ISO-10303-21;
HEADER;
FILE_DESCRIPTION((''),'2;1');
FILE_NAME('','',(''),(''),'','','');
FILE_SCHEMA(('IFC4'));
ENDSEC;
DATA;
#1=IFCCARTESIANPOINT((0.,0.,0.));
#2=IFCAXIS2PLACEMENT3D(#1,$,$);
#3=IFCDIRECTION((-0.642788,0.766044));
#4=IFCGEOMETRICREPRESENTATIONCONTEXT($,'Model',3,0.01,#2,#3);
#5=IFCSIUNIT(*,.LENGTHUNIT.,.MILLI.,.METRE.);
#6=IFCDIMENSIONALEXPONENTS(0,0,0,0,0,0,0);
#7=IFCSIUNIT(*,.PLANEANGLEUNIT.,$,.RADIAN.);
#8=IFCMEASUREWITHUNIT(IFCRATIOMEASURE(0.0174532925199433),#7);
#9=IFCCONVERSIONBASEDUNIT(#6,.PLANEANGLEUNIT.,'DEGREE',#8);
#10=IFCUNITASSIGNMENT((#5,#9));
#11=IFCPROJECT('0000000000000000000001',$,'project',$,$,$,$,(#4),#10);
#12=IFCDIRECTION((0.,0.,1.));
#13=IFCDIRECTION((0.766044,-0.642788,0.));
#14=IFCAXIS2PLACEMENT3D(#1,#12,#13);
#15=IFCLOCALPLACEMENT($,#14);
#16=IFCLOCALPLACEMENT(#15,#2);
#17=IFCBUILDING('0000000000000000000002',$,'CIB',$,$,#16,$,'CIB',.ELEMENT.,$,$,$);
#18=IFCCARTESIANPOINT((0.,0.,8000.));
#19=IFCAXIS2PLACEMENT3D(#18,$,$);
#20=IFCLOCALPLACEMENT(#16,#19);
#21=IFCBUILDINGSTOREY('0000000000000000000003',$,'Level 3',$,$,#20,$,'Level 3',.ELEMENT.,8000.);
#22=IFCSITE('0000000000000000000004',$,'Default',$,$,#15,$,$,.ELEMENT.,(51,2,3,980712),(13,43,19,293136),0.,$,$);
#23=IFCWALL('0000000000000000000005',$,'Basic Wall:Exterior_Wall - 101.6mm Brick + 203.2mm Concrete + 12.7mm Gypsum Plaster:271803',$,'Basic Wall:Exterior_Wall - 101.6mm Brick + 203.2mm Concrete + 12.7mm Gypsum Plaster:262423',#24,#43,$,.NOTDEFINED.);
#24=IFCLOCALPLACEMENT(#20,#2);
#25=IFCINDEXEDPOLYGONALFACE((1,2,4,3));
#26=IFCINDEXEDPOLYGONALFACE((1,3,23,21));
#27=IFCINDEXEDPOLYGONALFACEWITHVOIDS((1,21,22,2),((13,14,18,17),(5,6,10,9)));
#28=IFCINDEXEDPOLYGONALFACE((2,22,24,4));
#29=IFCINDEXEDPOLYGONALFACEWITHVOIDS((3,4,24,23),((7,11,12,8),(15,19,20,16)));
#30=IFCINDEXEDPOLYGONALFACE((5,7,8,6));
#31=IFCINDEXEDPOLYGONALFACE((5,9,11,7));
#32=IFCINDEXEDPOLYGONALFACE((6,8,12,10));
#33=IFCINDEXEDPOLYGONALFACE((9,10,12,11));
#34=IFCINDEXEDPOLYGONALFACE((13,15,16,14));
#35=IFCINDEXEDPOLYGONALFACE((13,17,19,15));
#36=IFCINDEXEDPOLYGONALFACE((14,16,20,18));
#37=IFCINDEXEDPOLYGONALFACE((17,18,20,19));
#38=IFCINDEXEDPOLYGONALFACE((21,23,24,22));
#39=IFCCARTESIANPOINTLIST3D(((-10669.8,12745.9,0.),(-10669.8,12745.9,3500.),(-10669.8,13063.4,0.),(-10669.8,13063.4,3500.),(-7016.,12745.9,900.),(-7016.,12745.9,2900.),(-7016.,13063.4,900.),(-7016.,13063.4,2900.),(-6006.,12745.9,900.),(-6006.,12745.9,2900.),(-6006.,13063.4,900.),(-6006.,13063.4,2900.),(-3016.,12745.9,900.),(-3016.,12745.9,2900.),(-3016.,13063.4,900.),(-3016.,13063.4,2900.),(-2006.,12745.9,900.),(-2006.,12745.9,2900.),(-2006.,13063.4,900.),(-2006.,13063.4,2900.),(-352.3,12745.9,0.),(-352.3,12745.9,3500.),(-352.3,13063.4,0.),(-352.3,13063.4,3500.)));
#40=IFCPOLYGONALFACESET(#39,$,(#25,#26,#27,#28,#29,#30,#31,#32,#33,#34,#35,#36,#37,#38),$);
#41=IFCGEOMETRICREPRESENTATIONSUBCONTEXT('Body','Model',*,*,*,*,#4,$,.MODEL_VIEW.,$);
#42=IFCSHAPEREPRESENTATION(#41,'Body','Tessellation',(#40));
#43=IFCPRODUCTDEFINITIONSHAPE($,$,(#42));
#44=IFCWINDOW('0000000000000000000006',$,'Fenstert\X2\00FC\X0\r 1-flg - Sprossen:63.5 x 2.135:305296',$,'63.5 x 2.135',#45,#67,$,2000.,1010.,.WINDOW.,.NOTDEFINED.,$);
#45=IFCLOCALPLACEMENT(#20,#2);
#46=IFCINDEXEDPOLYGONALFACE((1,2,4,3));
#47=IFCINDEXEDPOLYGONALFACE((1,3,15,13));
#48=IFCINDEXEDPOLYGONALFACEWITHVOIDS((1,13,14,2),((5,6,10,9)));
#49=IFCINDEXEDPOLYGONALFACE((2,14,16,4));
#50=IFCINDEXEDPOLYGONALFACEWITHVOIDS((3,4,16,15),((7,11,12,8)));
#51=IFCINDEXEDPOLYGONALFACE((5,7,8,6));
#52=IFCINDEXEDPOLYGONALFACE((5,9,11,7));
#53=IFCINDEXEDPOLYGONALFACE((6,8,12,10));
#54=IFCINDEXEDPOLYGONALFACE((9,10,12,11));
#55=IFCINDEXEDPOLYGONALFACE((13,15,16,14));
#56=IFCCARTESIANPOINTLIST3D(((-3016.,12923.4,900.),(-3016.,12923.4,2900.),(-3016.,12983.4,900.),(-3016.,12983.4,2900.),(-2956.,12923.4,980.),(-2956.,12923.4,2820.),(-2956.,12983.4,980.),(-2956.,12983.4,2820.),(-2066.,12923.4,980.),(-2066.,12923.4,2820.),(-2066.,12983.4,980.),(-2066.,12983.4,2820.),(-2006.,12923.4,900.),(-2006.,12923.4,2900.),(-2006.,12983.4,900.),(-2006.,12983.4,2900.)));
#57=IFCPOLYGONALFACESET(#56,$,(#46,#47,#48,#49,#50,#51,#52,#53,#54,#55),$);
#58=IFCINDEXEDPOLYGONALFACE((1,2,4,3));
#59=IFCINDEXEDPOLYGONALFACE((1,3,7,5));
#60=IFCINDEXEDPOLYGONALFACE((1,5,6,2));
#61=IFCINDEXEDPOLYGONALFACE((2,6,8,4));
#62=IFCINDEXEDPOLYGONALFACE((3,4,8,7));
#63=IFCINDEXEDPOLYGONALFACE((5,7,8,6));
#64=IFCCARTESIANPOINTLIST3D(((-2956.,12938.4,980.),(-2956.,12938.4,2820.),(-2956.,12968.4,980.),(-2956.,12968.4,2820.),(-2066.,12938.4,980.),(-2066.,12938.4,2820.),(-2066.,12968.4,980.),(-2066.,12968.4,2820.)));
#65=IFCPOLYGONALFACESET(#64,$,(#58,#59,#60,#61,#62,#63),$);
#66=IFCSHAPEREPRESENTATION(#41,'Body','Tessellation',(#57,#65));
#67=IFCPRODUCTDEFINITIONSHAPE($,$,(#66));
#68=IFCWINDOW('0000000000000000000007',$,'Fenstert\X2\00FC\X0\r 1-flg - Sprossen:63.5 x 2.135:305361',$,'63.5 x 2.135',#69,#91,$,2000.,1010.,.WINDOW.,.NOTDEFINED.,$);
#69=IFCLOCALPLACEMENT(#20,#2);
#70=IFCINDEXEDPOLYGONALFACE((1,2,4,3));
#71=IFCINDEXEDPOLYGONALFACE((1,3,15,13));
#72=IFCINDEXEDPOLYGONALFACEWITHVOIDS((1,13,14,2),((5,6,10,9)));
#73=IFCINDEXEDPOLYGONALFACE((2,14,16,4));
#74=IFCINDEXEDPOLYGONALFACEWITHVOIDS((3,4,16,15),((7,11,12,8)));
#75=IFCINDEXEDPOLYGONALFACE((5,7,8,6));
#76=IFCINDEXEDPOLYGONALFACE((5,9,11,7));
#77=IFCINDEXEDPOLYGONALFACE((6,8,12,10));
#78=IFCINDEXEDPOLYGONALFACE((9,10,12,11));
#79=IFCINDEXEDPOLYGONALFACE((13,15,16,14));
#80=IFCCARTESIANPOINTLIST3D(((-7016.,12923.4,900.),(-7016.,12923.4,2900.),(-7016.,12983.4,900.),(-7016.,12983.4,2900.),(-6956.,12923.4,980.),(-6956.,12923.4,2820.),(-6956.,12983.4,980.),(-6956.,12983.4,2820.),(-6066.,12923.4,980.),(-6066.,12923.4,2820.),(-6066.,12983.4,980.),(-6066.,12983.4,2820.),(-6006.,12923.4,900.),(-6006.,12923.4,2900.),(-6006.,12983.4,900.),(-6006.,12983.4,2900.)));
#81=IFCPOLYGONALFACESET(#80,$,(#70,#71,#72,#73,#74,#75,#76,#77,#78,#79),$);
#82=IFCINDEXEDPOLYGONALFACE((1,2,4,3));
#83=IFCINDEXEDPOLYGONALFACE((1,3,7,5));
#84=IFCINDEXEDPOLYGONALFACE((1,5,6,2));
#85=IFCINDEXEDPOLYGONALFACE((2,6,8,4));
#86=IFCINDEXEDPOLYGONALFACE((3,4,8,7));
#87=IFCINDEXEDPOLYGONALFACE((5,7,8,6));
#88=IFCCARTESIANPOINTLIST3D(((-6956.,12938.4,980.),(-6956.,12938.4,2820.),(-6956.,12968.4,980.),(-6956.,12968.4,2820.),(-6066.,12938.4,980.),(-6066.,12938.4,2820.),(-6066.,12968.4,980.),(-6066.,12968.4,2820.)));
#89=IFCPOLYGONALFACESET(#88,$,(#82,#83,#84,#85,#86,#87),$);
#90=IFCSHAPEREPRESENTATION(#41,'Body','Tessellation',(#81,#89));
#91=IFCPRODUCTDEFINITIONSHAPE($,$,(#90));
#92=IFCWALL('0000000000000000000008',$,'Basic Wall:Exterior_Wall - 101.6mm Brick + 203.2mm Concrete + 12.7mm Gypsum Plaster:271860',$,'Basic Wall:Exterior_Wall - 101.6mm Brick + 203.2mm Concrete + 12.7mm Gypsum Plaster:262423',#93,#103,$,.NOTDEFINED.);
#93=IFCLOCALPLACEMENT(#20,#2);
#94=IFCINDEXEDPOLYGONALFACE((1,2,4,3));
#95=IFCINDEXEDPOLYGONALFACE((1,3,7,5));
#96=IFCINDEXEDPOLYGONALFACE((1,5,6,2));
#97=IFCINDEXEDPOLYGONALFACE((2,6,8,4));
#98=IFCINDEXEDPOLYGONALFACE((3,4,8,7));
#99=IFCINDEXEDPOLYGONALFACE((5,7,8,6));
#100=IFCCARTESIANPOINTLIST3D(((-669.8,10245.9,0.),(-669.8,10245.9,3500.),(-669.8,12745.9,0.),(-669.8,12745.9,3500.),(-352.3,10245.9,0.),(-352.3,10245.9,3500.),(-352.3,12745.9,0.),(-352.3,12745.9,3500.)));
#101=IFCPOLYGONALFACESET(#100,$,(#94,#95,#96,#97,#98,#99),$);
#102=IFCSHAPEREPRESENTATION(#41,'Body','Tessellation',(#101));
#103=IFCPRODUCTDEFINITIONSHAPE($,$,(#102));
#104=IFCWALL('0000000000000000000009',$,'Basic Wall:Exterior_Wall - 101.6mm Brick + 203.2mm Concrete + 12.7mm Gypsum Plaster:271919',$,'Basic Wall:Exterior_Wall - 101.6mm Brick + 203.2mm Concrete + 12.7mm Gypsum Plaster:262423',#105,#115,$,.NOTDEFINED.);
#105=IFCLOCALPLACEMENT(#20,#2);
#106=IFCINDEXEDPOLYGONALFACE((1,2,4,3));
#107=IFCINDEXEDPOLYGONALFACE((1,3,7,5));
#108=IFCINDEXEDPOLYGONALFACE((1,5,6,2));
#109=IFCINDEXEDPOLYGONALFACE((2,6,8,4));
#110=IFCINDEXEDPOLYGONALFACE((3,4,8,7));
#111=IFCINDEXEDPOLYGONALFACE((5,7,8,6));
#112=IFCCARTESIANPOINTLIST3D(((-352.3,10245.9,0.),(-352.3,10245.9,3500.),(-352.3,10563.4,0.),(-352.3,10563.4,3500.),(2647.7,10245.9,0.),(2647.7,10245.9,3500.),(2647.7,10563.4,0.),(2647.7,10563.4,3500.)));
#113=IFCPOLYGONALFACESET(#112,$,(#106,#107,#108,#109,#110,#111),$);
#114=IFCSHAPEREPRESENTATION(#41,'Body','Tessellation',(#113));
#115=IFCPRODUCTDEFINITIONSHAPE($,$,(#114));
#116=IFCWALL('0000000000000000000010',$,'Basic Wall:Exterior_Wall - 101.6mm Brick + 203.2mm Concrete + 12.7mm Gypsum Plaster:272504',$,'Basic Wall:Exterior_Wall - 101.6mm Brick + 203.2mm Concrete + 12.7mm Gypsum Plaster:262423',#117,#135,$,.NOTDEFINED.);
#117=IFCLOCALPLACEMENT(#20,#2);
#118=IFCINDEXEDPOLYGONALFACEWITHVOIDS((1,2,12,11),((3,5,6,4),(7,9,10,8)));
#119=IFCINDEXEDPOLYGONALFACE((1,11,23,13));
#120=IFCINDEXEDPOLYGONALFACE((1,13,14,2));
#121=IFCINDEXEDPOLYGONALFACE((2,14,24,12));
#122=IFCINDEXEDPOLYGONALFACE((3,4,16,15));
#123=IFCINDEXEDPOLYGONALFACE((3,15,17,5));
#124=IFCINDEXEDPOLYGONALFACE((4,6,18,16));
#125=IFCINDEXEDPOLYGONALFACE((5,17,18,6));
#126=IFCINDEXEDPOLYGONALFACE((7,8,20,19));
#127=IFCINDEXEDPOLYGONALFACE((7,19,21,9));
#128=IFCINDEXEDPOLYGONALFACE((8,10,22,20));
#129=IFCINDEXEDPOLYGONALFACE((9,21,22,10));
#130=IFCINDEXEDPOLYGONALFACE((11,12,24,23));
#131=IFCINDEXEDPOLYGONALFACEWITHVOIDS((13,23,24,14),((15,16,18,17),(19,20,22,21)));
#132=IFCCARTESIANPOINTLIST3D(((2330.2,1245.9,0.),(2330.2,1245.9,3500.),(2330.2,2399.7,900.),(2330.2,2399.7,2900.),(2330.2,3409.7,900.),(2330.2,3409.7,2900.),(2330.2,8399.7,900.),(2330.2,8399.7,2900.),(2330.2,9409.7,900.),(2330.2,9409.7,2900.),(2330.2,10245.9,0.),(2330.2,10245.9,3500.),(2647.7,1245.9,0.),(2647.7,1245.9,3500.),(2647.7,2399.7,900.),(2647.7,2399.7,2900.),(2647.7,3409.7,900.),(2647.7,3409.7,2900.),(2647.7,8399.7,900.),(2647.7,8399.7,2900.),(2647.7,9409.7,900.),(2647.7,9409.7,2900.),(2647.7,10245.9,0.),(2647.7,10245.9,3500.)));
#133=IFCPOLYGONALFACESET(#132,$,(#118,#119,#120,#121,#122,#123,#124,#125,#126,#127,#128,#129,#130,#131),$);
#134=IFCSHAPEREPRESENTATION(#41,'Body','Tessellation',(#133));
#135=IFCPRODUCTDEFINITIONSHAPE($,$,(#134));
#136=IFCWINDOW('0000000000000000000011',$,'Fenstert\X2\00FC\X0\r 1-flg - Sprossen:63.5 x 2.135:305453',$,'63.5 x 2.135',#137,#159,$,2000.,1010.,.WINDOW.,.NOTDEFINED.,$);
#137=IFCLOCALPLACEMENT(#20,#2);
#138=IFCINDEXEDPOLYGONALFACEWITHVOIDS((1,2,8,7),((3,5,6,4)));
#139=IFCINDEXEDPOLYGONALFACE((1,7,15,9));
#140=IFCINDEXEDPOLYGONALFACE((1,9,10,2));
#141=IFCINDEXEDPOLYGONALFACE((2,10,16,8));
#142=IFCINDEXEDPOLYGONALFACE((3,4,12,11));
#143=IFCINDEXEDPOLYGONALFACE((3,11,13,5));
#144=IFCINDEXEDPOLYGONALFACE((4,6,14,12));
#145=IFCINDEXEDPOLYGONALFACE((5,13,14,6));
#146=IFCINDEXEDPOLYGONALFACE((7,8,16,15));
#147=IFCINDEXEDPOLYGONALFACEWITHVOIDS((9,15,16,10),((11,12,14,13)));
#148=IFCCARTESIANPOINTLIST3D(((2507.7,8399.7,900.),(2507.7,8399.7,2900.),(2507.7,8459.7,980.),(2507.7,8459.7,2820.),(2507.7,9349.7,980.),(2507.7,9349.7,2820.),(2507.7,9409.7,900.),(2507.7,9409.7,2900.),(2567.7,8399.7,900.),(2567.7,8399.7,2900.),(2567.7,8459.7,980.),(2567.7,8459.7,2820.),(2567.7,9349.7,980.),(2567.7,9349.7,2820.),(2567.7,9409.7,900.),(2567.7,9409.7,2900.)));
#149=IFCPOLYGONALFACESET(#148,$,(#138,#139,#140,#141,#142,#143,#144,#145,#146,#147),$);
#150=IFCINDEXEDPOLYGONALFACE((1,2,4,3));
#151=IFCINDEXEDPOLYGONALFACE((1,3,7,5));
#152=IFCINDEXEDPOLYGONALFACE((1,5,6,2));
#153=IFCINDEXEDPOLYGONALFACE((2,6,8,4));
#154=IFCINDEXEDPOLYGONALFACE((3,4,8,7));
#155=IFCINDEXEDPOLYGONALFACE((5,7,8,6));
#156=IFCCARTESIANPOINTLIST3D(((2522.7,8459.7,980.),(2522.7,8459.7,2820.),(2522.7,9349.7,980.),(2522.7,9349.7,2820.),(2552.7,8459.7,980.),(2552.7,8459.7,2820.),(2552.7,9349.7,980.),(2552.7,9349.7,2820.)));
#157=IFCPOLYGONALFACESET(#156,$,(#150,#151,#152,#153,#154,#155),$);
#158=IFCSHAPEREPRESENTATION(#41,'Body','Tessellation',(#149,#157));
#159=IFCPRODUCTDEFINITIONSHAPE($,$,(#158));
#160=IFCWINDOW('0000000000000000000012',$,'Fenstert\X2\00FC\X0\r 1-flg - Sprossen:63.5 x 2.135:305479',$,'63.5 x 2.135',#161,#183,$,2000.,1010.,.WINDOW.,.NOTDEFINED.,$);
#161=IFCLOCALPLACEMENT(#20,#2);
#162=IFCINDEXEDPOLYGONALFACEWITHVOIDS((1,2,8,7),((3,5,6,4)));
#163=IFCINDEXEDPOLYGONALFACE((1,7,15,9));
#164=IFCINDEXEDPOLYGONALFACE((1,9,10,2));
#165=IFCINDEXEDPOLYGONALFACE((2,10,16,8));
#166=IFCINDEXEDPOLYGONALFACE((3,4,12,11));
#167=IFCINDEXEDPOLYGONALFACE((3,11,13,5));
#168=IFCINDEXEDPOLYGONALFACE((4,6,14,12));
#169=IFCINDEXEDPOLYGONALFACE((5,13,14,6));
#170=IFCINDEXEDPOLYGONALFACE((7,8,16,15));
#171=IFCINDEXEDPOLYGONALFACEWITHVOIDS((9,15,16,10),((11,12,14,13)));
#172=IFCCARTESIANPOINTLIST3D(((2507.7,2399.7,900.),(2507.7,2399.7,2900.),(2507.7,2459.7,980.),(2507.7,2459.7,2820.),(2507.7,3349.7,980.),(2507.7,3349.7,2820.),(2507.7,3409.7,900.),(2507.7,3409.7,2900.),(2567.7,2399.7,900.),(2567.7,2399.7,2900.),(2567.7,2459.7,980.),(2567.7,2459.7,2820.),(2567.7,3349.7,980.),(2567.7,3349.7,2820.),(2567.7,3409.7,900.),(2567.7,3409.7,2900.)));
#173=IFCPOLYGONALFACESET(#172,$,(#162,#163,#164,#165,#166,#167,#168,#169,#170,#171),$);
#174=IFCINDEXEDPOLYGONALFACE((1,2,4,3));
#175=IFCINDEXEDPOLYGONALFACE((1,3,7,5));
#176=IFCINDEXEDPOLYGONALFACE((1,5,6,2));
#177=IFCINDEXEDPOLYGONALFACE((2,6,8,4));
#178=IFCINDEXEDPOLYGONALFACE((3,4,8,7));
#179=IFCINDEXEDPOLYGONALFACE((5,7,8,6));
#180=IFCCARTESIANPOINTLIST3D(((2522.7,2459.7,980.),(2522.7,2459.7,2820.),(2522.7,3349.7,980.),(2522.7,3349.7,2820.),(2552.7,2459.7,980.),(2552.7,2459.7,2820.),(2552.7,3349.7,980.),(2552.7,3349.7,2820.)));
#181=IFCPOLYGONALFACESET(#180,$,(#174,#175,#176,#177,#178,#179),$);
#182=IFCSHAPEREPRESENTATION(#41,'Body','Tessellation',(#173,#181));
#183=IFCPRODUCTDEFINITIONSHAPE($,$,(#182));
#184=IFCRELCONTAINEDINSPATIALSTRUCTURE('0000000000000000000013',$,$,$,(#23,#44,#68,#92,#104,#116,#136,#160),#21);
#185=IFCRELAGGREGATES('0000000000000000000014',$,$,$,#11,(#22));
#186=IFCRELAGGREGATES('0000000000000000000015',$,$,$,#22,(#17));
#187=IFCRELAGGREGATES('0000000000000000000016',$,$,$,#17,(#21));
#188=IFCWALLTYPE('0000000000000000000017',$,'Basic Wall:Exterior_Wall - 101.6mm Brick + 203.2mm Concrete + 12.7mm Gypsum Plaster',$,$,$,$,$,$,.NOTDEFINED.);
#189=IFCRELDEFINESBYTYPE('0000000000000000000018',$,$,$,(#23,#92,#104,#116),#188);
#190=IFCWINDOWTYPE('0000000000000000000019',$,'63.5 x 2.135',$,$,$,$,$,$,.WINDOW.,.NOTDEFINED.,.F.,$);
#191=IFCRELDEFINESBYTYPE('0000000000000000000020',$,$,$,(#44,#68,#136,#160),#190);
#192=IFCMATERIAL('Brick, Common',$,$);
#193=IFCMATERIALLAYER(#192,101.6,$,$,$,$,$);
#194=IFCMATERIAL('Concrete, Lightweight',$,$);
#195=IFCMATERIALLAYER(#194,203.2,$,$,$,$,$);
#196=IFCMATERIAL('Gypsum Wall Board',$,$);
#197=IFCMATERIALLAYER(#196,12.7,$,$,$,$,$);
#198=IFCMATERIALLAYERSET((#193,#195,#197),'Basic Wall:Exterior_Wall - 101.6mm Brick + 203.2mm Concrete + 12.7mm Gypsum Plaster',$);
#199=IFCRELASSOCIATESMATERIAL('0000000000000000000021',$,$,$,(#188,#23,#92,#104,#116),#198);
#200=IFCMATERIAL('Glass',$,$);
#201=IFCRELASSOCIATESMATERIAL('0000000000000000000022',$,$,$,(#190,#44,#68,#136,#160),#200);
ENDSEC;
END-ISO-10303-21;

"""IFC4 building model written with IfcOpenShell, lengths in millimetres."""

from ifc_helpers import new_model, entity, si_unit, converted_unit, direction, frame, frame_2d, origin, origin_2d_with_axis, place, context, subcontext, project, spatial, polyline, rectangle, outline, extrude, source, transform, mapped, material, layer, layer_set, layer_usage, type_object, type_shapes, element, fill, save


model = new_model("IFC4")

# Units and contexts
model_context = context("Model", 3, precision=0.01, world=origin(), true_north=direction((-0.642788, 0.766044)))
body_context = subcontext(model_context, "Body", "Model", "MODEL_VIEW")
ifc_project = project(units=[si_unit("LENGTHUNIT", "METRE", prefix="MILLI"), converted_unit("PLANEANGLEUNIT", "DEGREE", entity("IfcRatioMeasure", 0.0174532925199433), si_unit("PLANEANGLEUNIT", "RADIAN"), dimensions=[0, 0, 0, 0, 0, 0, 0])], contexts=[model_context])

# Site, building, storey
site_placement = place(None, frame((0.0, 0.0, 0.0), z_axis=(0.0, 0.0, 1.0), x_axis=(0.766044, -0.642788, 0.0)))
site = spatial("IfcSite", under=ifc_project, at=site_placement, Name="Default", CompositionType="ELEMENT", RefLatitude=(51, 2, 3, 980712), RefLongitude=(13, 43, 19, 293136), RefElevation=0.0)
building_placement = place(site_placement, origin())
building = spatial("IfcBuilding", under=site, at=building_placement, Name="CIB", LongName="CIB", CompositionType="ELEMENT")
storey_placement = place(building_placement, frame((0.0, 0.0, 8000.0)))
storey = spatial("IfcBuildingStorey", under=building, at=storey_placement, Name="Level 3", LongName="Level 3", CompositionType="ELEMENT", Elevation=8000.0)

# Wall, openings, windows
ifc_material_1 = material(Name="Brick, Common")
ifc_layer_1 = layer(ifc_material_1, 101.6)
ifc_material_2 = material(Name="Concrete, Lightweight")
ifc_layer_2 = layer(ifc_material_2, 203.2)
ifc_material_3 = material(Name="Gypsum Wall Board")
ifc_layer_3 = layer(ifc_material_3, 12.7)
ifc_layer_set_1 = layer_set([ifc_layer_1, ifc_layer_2, ifc_layer_3], Name="Basic Wall:Exterior_Wall - 101.6mm Brick + 203.2mm Concrete + 12.7mm Gypsum Plaster")
ifc_layer_usage_1 = layer_usage(ifc_layer_set_1, "AXIS2", "NEGATIVE", 158.8)
wall_type_1 = type_object("IfcWallType", Name="Basic Wall:Exterior_Wall - 101.6mm Brick + 203.2mm Concrete + 12.7mm Gypsum Plaster", PredefinedType="NOTDEFINED", material=ifc_layer_set_1)
wall_1_placement = place(storey_placement, frame((-10669.8, 12904.7, 0.0)))
wall_1 = element("IfcWall", 1, at=wall_1_placement, inside=storey, type_object=wall_type_1, material=ifc_layer_usage_1, Name="Basic Wall:Exterior_Wall - 101.6mm Brick + 203.2mm Concrete + 12.7mm Gypsum Plaster:271803", ObjectType="Basic Wall:Exterior_Wall - 101.6mm Brick + 203.2mm Concrete + 12.7mm Gypsum Plaster:262423", PredefinedType="NOTDEFINED", context=body_context, shape_type="SweptSolid", body=[
    extrude(rectangle(XDim=10317.5, YDim=317.5, at=frame_2d((5158.7, 0.0), x_axis=(-1.0, 0.0))), origin(), (0.0, 0.0, 1.0), 3500.0),
])
opening_1_placement = place(wall_1_placement, frame((8663.7, 158.7, 900.0)))
opening_1 = element("IfcOpeningElement", 2, at=opening_1_placement, cuts=wall_1, ObjectType="Opening", PredefinedType="OPENING", context=body_context, shape_type="SweptSolid", body=[
    extrude(rectangle(XDim=2000.0, YDim=1010.0, at=frame_2d((1000.0, 505.0), x_axis=(1.0, 0.0))), frame((0.0, 0.0, 0.0), z_axis=(0.0, -1.0, 0.0), x_axis=(0.0, 0.0, 1.0)), (0.0, 0.0, 1.0), 317.5),
])
opening_2_placement = place(wall_1_placement, frame((4663.7, 158.7, 900.0)))
opening_2 = element("IfcOpeningElement", 3, at=opening_2_placement, cuts=wall_1, ObjectType="Opening", PredefinedType="OPENING", context=body_context, shape_type="SweptSolid", body=[
    extrude(rectangle(XDim=2000.0, YDim=1010.0, at=frame_2d((1000.0, 505.0), x_axis=(1.0, 0.0))), frame((0.0, 0.0, 0.0), z_axis=(0.0, -1.0, 0.0), x_axis=(0.0, 0.0, 1.0)), (0.0, 0.0, 1.0), 317.5),
])
ifc_material_4 = material(Name="Glass")
window_type = type_object("IfcWindowType", Name="63.5 x 2.135", ParameterTakesPrecedence=False, PartitioningType="NOTDEFINED", PredefinedType="WINDOW", material=ifc_material_4)
shared_shape_1 = source(origin(), body_context, "Body", "SweptSolid", [
    extrude(outline(polyline([(-1000.0, -505.0), (1000.0, -505.0), (1000.0, 505.0), (-1000.0, 505.0), (-1000.0, -505.0)]), holes=[polyline([(-920.0, -445.0), (-920.0, 445.0), (920.0, 445.0), (920.0, -445.0), (-920.0, -445.0)])]), frame((505.0, 177.5, 1000.0), z_axis=(0.0, 1.0, 0.0), x_axis=(0.0, 0.0, -1.0)), (0.0, 0.0, 1.0), 60.0),
    extrude(rectangle(XDim=30.0, YDim=890.0, at=origin_2d_with_axis()), frame((505.0, 207.5, 80.0), z_axis=(0.0, 0.0, 1.0), x_axis=(0.0, 1.0, 0.0)), (0.0, 0.0, 1.0), 1840.0),
])
type_shapes(window_type, [shared_shape_1])
window_1_placement = place(opening_1_placement, frame((-1010.0, -317.5, 0.0)))
window_1 = element("IfcWindow", 4, at=window_1_placement, inside=storey, type_object=window_type, material=ifc_material_4, Name="Fenstertür 1-flg - Sprossen:63.5 x 2.135:305296", ObjectType="63.5 x 2.135", OverallHeight=2000.0, OverallWidth=1010.0, PartitioningType="NOTDEFINED", PredefinedType="WINDOW", context=body_context, shape_type="MappedRepresentation", body=[
    mapped(shared_shape_1, transform((0.0, 0.0, 0.0), scale=1.0)),
])
fill(opening_1, window_1)
window_2_placement = place(opening_2_placement, frame((-1010.0, -317.5, 0.0)))
window_2 = element("IfcWindow", 5, at=window_2_placement, inside=storey, type_object=window_type, material=ifc_material_4, Name="Fenstertür 1-flg - Sprossen:63.5 x 2.135:305361", ObjectType="63.5 x 2.135", OverallHeight=2000.0, OverallWidth=1010.0, PartitioningType="NOTDEFINED", PredefinedType="WINDOW", context=body_context, shape_type="MappedRepresentation", body=[
    mapped(shared_shape_1, transform((0.0, 0.0, 0.0), scale=1.0)),
])
fill(opening_2, window_2)

# Walls
ifc_layer_usage_2 = layer_usage(ifc_layer_set_1, "AXIS2", "NEGATIVE", 158.8)
wall_2_placement = place(storey_placement, frame((-511.0, 12745.9, 0.0), z_axis=(0.0, 0.0, 1.0), x_axis=(0.0, -1.0, 0.0)))
element("IfcWall", 6, at=wall_2_placement, inside=storey, type_object=wall_type_1, material=ifc_layer_usage_2, Name="Basic Wall:Exterior_Wall - 101.6mm Brick + 203.2mm Concrete + 12.7mm Gypsum Plaster:271860", ObjectType="Basic Wall:Exterior_Wall - 101.6mm Brick + 203.2mm Concrete + 12.7mm Gypsum Plaster:262423", PredefinedType="NOTDEFINED", context=body_context, shape_type="SweptSolid", body=[
    extrude(rectangle(XDim=2500.0, YDim=317.5, at=frame_2d((1250.0, 0.0), x_axis=(-1.0, 0.0))), origin(), (0.0, 0.0, 1.0), 3500.0),
])
ifc_layer_usage_3 = layer_usage(ifc_layer_set_1, "AXIS2", "NEGATIVE", 158.8)
wall_3_placement = place(storey_placement, frame((-352.3, 10404.7, 0.0)))
element("IfcWall", 7, at=wall_3_placement, inside=storey, type_object=wall_type_1, material=ifc_layer_usage_3, Name="Basic Wall:Exterior_Wall - 101.6mm Brick + 203.2mm Concrete + 12.7mm Gypsum Plaster:271919", ObjectType="Basic Wall:Exterior_Wall - 101.6mm Brick + 203.2mm Concrete + 12.7mm Gypsum Plaster:262423", PredefinedType="NOTDEFINED", context=body_context, shape_type="SweptSolid", body=[
    extrude(rectangle(XDim=3000.0, YDim=317.5, at=frame_2d((1500.0, 0.0), x_axis=(-1.0, 0.0))), origin(), (0.0, 0.0, 1.0), 3500.0),
])

# Wall, openings, windows
ifc_layer_usage_4 = layer_usage(ifc_layer_set_1, "AXIS2", "NEGATIVE", 158.8)
wall_4_placement = place(storey_placement, frame((2489.0, 10245.9, 0.0), z_axis=(0.0, 0.0, 1.0), x_axis=(0.0, -1.0, 0.0)))
wall_4 = element("IfcWall", 8, at=wall_4_placement, inside=storey, type_object=wall_type_1, material=ifc_layer_usage_4, Name="Basic Wall:Exterior_Wall - 101.6mm Brick + 203.2mm Concrete + 12.7mm Gypsum Plaster:272504", ObjectType="Basic Wall:Exterior_Wall - 101.6mm Brick + 203.2mm Concrete + 12.7mm Gypsum Plaster:262423", PredefinedType="NOTDEFINED", context=body_context, shape_type="SweptSolid", body=[
    extrude(rectangle(XDim=9000.0, YDim=317.5, at=frame_2d((4500.0, 0.0), x_axis=(-1.0, 0.0))), origin(), (0.0, 0.0, 1.0), 3500.0),
])
opening_3_placement = place(wall_4_placement, frame((1846.2, 158.7, 900.0)))
opening_3 = element("IfcOpeningElement", 9, at=opening_3_placement, cuts=wall_4, ObjectType="Opening", PredefinedType="OPENING", context=body_context, shape_type="SweptSolid", body=[
    extrude(rectangle(XDim=2000.0, YDim=1010.0, at=frame_2d((1000.0, 505.0), x_axis=(1.0, 0.0))), frame((0.0, 0.0, 0.0), z_axis=(0.0, -1.0, 0.0), x_axis=(0.0, 0.0, 1.0)), (0.0, 0.0, 1.0), 317.5),
])
opening_4_placement = place(wall_4_placement, frame((7846.2, 158.7, 900.0)))
opening_4 = element("IfcOpeningElement", 10, at=opening_4_placement, cuts=wall_4, ObjectType="Opening", PredefinedType="OPENING", context=body_context, shape_type="SweptSolid", body=[
    extrude(rectangle(XDim=2000.0, YDim=1010.0, at=frame_2d((1000.0, 505.0), x_axis=(1.0, 0.0))), frame((0.0, 0.0, 0.0), z_axis=(0.0, -1.0, 0.0), x_axis=(0.0, 0.0, 1.0)), (0.0, 0.0, 1.0), 317.5),
])
window_3_placement = place(opening_3_placement, frame((-1010.0, -317.5, 0.0)))
window_3 = element("IfcWindow", 11, at=window_3_placement, inside=storey, type_object=window_type, material=ifc_material_4, Name="Fenstertür 1-flg - Sprossen:63.5 x 2.135:305453", ObjectType="63.5 x 2.135", OverallHeight=2000.0, OverallWidth=1010.0, PartitioningType="NOTDEFINED", PredefinedType="WINDOW", context=body_context, shape_type="MappedRepresentation", body=[
    mapped(shared_shape_1, transform((0.0, 0.0, 0.0), scale=1.0)),
])
fill(opening_3, window_3)
window_4_placement = place(opening_4_placement, frame((-1010.0, -317.5, 0.0)))
window_4 = element("IfcWindow", 12, at=window_4_placement, inside=storey, type_object=window_type, material=ifc_material_4, Name="Fenstertür 1-flg - Sprossen:63.5 x 2.135:305479", ObjectType="63.5 x 2.135", OverallHeight=2000.0, OverallWidth=1010.0, PartitioningType="NOTDEFINED", PredefinedType="WINDOW", context=body_context, shape_type="MappedRepresentation", body=[
    mapped(shared_shape_1, transform((0.0, 0.0, 0.0), scale=1.0)),
])
fill(opening_4, window_4)

save(model, "model.ifc")
